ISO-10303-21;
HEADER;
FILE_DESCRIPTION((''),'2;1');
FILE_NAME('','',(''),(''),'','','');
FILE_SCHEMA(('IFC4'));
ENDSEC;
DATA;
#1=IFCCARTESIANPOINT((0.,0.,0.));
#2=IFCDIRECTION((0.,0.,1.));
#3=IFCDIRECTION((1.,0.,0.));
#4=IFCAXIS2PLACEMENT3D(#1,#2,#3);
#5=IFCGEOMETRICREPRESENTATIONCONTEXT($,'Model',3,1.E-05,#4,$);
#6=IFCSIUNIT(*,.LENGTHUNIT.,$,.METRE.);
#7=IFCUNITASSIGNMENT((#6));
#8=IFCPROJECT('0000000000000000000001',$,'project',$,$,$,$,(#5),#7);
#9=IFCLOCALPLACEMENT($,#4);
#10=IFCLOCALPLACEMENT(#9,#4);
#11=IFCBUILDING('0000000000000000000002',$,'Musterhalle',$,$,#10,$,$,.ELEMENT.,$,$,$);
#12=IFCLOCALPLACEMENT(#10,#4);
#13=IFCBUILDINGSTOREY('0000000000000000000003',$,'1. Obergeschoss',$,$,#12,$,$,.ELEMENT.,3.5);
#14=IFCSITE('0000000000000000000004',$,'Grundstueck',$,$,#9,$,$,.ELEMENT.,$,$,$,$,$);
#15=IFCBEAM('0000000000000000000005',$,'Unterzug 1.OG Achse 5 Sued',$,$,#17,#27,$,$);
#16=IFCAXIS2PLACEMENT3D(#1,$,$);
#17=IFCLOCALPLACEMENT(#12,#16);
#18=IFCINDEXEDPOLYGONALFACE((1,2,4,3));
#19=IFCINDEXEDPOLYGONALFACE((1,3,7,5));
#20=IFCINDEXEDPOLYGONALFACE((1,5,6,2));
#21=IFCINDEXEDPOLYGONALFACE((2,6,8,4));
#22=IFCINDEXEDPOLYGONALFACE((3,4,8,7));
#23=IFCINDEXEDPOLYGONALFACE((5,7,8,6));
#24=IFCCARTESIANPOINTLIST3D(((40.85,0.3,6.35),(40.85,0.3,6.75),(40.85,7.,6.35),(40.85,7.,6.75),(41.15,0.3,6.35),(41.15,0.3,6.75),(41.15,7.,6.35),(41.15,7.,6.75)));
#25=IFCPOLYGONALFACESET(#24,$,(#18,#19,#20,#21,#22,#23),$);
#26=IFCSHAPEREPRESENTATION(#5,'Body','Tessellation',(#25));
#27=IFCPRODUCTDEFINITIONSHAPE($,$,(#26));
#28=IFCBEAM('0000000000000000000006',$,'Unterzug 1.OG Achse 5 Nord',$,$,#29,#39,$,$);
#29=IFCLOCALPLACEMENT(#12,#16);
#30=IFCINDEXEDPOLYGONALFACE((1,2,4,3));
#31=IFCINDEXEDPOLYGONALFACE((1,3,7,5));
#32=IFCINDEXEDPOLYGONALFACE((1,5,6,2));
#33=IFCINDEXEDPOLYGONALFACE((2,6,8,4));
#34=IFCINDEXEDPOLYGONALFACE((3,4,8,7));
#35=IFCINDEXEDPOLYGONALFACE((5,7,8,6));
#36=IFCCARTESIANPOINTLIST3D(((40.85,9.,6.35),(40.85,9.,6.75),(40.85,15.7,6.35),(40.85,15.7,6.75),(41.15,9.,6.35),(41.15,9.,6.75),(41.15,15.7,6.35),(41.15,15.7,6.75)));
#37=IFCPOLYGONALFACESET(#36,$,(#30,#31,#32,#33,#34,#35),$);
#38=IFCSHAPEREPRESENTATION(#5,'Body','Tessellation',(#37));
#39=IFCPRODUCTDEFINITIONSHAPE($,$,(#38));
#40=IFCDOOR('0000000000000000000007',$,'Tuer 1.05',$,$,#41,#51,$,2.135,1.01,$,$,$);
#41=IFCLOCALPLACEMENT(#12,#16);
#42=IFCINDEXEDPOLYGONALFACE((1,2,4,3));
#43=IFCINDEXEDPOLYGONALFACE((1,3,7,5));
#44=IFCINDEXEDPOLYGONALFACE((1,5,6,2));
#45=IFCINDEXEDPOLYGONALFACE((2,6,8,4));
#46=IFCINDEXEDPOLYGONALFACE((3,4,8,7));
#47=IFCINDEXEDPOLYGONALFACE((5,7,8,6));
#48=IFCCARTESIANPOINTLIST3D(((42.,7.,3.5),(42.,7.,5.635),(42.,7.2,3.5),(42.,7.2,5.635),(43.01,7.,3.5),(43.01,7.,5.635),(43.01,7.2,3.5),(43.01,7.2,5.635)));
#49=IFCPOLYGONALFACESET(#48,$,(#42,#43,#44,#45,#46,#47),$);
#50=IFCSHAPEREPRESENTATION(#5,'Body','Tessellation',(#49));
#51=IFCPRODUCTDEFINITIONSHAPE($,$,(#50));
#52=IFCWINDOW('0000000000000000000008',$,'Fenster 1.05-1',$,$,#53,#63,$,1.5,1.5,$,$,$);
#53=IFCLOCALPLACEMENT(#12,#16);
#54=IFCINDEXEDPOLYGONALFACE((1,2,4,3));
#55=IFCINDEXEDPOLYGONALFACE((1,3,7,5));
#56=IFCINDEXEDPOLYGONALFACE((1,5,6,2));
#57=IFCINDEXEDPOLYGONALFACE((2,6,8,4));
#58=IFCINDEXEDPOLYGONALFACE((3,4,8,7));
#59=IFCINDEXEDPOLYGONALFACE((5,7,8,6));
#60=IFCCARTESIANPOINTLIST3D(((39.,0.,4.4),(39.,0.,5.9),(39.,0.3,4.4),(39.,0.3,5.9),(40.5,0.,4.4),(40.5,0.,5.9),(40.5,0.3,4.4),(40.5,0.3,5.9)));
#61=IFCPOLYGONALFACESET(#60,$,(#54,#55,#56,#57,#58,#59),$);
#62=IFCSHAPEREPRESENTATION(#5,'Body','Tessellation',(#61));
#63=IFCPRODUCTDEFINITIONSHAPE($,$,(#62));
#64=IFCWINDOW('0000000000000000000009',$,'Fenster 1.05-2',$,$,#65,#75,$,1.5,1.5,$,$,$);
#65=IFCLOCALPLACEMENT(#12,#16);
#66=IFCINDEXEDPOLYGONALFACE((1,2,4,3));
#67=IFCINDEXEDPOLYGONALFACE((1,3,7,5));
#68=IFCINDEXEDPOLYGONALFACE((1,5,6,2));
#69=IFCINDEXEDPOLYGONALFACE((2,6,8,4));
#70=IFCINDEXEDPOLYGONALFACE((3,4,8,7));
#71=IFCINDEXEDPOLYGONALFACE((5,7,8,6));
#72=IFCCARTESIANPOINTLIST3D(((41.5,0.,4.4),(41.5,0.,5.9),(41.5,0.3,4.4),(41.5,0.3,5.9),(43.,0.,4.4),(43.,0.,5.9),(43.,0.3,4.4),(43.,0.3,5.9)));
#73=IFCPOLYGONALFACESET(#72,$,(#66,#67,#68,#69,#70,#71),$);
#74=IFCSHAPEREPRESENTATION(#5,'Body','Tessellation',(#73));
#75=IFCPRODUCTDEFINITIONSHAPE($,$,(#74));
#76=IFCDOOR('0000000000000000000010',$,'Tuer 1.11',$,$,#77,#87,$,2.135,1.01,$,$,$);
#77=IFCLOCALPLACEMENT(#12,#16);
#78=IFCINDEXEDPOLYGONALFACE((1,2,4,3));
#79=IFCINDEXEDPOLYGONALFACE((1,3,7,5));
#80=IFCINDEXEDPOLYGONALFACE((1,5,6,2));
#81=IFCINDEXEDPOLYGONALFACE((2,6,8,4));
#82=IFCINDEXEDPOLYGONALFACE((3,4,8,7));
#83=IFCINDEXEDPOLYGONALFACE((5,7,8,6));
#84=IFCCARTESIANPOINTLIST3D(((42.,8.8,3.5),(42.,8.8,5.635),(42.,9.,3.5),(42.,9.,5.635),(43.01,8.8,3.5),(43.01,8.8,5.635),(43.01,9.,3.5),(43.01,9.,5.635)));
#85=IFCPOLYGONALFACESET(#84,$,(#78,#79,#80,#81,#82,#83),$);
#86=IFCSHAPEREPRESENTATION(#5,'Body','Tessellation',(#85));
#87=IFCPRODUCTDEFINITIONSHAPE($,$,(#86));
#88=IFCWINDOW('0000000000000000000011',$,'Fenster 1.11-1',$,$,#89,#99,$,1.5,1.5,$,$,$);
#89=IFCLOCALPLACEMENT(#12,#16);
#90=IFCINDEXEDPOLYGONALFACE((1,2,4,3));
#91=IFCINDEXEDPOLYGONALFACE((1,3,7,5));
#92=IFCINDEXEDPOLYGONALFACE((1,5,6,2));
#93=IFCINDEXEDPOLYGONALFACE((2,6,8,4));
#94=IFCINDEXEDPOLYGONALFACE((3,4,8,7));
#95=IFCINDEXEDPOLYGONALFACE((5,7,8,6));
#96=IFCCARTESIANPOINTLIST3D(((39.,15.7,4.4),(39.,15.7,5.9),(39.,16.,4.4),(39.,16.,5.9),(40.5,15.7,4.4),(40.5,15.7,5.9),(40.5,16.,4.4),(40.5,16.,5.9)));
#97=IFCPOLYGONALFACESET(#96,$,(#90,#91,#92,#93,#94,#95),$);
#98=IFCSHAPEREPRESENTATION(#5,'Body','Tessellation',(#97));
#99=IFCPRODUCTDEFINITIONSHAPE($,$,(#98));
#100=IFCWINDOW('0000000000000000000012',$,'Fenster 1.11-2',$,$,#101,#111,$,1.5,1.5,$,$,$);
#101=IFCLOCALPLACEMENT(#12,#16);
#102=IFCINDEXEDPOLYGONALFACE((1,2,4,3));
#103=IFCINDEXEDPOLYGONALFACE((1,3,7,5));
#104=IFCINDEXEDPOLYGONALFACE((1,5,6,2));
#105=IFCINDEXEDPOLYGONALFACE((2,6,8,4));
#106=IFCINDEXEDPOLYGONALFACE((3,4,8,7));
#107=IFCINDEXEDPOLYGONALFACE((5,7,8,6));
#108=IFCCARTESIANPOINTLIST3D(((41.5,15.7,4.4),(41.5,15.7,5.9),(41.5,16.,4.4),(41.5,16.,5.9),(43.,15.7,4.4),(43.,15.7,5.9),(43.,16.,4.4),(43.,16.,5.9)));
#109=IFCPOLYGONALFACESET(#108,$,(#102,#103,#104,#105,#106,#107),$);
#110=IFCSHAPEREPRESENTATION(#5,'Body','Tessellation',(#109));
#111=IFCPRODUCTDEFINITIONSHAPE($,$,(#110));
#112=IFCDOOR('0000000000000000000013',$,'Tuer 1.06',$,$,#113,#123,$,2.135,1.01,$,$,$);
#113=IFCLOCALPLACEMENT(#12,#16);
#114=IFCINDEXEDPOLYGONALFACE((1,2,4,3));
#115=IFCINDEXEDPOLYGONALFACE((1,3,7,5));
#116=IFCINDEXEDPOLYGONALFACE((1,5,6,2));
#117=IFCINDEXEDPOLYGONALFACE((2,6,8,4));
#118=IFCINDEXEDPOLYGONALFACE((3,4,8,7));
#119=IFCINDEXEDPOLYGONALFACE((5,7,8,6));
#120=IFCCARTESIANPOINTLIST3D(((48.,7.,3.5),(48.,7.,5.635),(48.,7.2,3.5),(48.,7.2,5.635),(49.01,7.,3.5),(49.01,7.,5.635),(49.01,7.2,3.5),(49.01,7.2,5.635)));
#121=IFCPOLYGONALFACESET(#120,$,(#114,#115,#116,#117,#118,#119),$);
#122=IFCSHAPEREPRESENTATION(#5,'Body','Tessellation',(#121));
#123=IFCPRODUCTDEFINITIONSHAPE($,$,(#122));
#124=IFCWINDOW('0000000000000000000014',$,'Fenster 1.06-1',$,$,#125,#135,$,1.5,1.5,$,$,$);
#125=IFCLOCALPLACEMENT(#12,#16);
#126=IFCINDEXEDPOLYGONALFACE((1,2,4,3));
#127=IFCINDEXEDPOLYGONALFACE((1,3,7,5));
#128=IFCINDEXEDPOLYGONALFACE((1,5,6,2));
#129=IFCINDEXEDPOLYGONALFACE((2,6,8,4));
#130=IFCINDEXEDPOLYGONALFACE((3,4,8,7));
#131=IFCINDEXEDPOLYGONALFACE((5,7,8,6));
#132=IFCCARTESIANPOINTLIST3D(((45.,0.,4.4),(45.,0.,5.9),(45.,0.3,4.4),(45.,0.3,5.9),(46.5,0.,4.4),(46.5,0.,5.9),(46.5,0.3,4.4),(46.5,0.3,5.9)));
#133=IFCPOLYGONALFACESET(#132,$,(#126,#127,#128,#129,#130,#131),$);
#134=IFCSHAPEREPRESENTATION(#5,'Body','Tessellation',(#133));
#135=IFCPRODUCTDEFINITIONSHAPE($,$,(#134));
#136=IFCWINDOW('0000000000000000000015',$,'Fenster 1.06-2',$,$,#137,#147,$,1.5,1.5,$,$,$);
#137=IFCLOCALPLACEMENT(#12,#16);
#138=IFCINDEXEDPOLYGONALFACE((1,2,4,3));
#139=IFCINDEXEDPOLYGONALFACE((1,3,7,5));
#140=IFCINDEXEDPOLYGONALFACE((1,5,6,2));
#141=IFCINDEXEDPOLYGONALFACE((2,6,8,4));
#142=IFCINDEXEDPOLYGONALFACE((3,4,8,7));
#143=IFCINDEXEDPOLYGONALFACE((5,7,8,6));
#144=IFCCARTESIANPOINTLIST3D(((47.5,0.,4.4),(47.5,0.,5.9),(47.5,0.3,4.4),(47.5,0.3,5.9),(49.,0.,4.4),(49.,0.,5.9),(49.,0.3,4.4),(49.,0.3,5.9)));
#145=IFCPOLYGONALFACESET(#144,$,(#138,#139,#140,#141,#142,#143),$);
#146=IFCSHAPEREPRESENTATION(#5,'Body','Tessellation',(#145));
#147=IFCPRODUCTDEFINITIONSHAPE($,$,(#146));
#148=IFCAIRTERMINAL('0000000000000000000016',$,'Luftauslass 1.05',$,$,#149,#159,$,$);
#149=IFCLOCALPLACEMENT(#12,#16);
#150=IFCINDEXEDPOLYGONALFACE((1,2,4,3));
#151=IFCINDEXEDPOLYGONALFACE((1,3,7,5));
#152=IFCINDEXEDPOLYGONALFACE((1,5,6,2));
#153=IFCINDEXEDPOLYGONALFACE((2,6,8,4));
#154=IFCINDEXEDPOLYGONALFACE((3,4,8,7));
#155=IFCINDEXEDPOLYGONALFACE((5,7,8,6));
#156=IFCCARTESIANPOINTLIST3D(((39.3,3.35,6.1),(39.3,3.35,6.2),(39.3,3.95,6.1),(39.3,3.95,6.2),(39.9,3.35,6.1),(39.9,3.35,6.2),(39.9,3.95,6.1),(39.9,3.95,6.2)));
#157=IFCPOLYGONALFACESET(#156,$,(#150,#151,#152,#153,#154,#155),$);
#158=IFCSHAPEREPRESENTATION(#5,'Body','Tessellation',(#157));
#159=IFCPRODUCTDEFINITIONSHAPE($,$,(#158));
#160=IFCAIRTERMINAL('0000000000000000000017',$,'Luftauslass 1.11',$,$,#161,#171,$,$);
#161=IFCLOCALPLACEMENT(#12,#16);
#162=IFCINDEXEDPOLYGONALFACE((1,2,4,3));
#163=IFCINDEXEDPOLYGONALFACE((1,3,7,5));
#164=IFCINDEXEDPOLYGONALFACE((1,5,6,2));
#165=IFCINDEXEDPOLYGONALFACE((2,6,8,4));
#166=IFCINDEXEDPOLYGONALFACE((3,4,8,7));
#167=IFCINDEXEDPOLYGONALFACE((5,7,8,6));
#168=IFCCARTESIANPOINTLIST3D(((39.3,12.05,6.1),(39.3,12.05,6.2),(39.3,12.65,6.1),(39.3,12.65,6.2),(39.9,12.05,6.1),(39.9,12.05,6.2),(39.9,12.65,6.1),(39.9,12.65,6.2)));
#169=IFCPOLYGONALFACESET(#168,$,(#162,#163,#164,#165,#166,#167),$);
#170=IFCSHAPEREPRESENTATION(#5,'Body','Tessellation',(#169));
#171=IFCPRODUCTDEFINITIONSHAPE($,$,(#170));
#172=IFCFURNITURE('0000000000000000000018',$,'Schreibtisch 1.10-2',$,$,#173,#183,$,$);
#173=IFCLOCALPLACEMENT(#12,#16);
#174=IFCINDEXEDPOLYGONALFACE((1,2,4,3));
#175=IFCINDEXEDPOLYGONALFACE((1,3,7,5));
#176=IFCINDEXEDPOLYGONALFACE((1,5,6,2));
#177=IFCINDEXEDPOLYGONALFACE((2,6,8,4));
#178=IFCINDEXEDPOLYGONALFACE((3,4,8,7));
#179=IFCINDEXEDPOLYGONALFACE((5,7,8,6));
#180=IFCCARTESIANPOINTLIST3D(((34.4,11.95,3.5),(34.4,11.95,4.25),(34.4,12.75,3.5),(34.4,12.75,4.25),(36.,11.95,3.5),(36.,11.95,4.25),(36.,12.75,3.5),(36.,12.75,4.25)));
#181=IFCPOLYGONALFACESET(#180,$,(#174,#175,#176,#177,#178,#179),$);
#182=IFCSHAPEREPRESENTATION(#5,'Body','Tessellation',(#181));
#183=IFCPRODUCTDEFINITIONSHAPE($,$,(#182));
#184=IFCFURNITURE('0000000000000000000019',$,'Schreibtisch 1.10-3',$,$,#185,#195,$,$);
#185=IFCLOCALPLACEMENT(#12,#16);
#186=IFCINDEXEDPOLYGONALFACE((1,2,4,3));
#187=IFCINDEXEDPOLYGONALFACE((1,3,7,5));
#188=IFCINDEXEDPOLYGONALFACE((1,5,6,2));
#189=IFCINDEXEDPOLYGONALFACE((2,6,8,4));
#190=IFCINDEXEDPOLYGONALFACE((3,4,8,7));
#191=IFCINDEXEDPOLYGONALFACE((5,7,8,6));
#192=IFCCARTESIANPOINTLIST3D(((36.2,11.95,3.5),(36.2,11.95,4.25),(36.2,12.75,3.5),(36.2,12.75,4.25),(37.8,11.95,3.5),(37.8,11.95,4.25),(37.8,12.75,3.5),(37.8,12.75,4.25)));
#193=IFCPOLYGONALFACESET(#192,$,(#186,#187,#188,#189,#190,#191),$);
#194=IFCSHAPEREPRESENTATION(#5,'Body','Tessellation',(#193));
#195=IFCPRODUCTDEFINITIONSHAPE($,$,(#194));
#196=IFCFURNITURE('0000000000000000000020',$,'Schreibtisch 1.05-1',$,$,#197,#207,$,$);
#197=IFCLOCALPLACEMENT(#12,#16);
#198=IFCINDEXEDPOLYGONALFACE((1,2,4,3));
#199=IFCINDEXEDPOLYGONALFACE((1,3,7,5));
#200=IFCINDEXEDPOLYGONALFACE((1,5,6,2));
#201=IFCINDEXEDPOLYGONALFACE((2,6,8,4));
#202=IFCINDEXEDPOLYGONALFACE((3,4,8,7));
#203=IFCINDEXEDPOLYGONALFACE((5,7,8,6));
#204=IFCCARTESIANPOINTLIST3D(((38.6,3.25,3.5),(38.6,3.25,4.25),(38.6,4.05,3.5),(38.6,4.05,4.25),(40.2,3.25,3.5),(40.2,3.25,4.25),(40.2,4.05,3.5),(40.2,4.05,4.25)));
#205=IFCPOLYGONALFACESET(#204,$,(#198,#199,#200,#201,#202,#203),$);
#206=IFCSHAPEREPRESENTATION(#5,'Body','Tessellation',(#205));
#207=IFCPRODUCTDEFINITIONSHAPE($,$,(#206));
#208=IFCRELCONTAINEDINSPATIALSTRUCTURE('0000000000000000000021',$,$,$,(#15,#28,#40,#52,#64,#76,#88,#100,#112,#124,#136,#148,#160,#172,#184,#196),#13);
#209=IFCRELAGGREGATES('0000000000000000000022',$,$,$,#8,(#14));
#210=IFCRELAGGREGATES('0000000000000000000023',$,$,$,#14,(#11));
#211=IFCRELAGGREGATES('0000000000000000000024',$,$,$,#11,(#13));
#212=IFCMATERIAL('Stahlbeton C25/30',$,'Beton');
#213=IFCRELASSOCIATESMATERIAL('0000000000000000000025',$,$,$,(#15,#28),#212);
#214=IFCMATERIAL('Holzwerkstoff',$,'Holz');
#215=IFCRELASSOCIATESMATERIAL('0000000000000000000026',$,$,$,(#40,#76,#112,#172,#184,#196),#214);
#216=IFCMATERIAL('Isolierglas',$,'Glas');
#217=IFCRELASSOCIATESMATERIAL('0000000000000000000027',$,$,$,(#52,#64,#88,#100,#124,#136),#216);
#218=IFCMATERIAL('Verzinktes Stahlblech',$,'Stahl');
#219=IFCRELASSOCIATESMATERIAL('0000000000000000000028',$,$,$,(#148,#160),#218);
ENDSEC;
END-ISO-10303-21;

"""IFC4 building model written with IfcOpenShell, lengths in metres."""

from ifc_helpers import new_model, si_unit, frame, origin_with_axes, origin_2d, place, context, project, spatial, rectangle, extrude, material, element, save


model = new_model("IFC4")

# Units and contexts
model_context = context("Model", 3, precision=1e-05, world=origin_with_axes())
ifc_project = project(units=[si_unit("LENGTHUNIT", "METRE")], contexts=[model_context])

# Site, building, storey
site_placement = place(None, origin_with_axes())
site = spatial("IfcSite", under=ifc_project, at=site_placement, Name="Grundstueck", CompositionType="ELEMENT")
building_placement = place(site_placement, origin_with_axes())
building = spatial("IfcBuilding", under=site, at=building_placement, Name="Musterhalle", CompositionType="ELEMENT")
storey_placement = place(building_placement, origin_with_axes())
storey = spatial("IfcBuildingStorey", under=building, at=storey_placement, Name="1. Obergeschoss", CompositionType="ELEMENT", Elevation=3.5)

# Beams
ifc_material_1 = material(Name="Stahlbeton C25/30", Category="Beton")
placement = place(storey_placement, origin_with_axes())
element("IfcBeam", 1, at=placement, inside=storey, material=ifc_material_1, Name="Unterzug 1.OG Achse 5 Sued", context=model_context, shape_type="SweptSolid", body=[
    extrude(rectangle(XDim=0.3, YDim=6.7, at=origin_2d()), frame((41.0, 3.65, 6.35), z_axis=(0.0, 0.0, 1.0), x_axis=(1.0, 0.0, 0.0)), (0.0, 0.0, 1.0), 0.4),
])
element("IfcBeam", 2, at=placement, inside=storey, material=ifc_material_1, Name="Unterzug 1.OG Achse 5 Nord", context=model_context, shape_type="SweptSolid", body=[
    extrude(rectangle(XDim=0.3, YDim=6.7, at=origin_2d()), frame((41.0, 12.35, 6.35), z_axis=(0.0, 0.0, 1.0), x_axis=(1.0, 0.0, 0.0)), (0.0, 0.0, 1.0), 0.4),
])

# Door
ifc_material_2 = material(Name="Holzwerkstoff", Category="Holz")
element("IfcDoor", 3, at=placement, inside=storey, material=ifc_material_2, Name="Tuer 1.05", OverallHeight=2.135, OverallWidth=1.01, context=model_context, shape_type="SweptSolid", body=[
    extrude(rectangle(XDim=1.01, YDim=0.2, at=origin_2d()), frame((42.505, 7.1, 3.5), z_axis=(0.0, 0.0, 1.0), x_axis=(1.0, 0.0, 0.0)), (0.0, 0.0, 1.0), 2.135),
])

# Windows
ifc_material_3 = material(Name="Isolierglas", Category="Glas")
element("IfcWindow", 4, at=placement, inside=storey, material=ifc_material_3, Name="Fenster 1.05-1", OverallHeight=1.5, OverallWidth=1.5, context=model_context, shape_type="SweptSolid", body=[
    extrude(rectangle(XDim=1.5, YDim=0.3, at=origin_2d()), frame((39.75, 0.15, 4.4), z_axis=(0.0, 0.0, 1.0), x_axis=(1.0, 0.0, 0.0)), (0.0, 0.0, 1.0), 1.5),
])
element("IfcWindow", 5, at=placement, inside=storey, material=ifc_material_3, Name="Fenster 1.05-2", OverallHeight=1.5, OverallWidth=1.5, context=model_context, shape_type="SweptSolid", body=[
    extrude(rectangle(XDim=1.5, YDim=0.3, at=origin_2d()), frame((42.25, 0.15, 4.4), z_axis=(0.0, 0.0, 1.0), x_axis=(1.0, 0.0, 0.0)), (0.0, 0.0, 1.0), 1.5),
])

# Door
element("IfcDoor", 6, at=placement, inside=storey, material=ifc_material_2, Name="Tuer 1.11", OverallHeight=2.135, OverallWidth=1.01, context=model_context, shape_type="SweptSolid", body=[
    extrude(rectangle(XDim=1.01, YDim=0.2, at=origin_2d()), frame((42.505, 8.9, 3.5), z_axis=(0.0, 0.0, 1.0), x_axis=(1.0, 0.0, 0.0)), (0.0, 0.0, 1.0), 2.135),
])

# Windows
element("IfcWindow", 7, at=placement, inside=storey, material=ifc_material_3, Name="Fenster 1.11-1", OverallHeight=1.5, OverallWidth=1.5, context=model_context, shape_type="SweptSolid", body=[
    extrude(rectangle(XDim=1.5, YDim=0.3, at=origin_2d()), frame((39.75, 15.85, 4.4), z_axis=(0.0, 0.0, 1.0), x_axis=(1.0, 0.0, 0.0)), (0.0, 0.0, 1.0), 1.5),
])
element("IfcWindow", 8, at=placement, inside=storey, material=ifc_material_3, Name="Fenster 1.11-2", OverallHeight=1.5, OverallWidth=1.5, context=model_context, shape_type="SweptSolid", body=[
    extrude(rectangle(XDim=1.5, YDim=0.3, at=origin_2d()), frame((42.25, 15.85, 4.4), z_axis=(0.0, 0.0, 1.0), x_axis=(1.0, 0.0, 0.0)), (0.0, 0.0, 1.0), 1.5),
])

# Door
element("IfcDoor", 9, at=placement, inside=storey, material=ifc_material_2, Name="Tuer 1.06", OverallHeight=2.135, OverallWidth=1.01, context=model_context, shape_type="SweptSolid", body=[
    extrude(rectangle(XDim=1.01, YDim=0.2, at=origin_2d()), frame((48.505, 7.1, 3.5), z_axis=(0.0, 0.0, 1.0), x_axis=(1.0, 0.0, 0.0)), (0.0, 0.0, 1.0), 2.135),
])

# Windows
element("IfcWindow", 10, at=placement, inside=storey, material=ifc_material_3, Name="Fenster 1.06-1", OverallHeight=1.5, OverallWidth=1.5, context=model_context, shape_type="SweptSolid", body=[
    extrude(rectangle(XDim=1.5, YDim=0.3, at=origin_2d()), frame((45.75, 0.15, 4.4), z_axis=(0.0, 0.0, 1.0), x_axis=(1.0, 0.0, 0.0)), (0.0, 0.0, 1.0), 1.5),
])
element("IfcWindow", 11, at=placement, inside=storey, material=ifc_material_3, Name="Fenster 1.06-2", OverallHeight=1.5, OverallWidth=1.5, context=model_context, shape_type="SweptSolid", body=[
    extrude(rectangle(XDim=1.5, YDim=0.3, at=origin_2d()), frame((48.25, 0.15, 4.4), z_axis=(0.0, 0.0, 1.0), x_axis=(1.0, 0.0, 0.0)), (0.0, 0.0, 1.0), 1.5),
])

# Air terminals
ifc_material_4 = material(Name="Verzinktes Stahlblech", Category="Stahl")
element("IfcAirTerminal", 12, at=placement, inside=storey, material=ifc_material_4, Name="Luftauslass 1.05", context=model_context, shape_type="SweptSolid", body=[
    extrude(rectangle(XDim=0.6, YDim=0.6, at=origin_2d()), frame((39.6, 3.65, 6.1), z_axis=(0.0, 0.0, 1.0), x_axis=(1.0, 0.0, 0.0)), (0.0, 0.0, 1.0), 0.1),
])
element("IfcAirTerminal", 13, at=placement, inside=storey, material=ifc_material_4, Name="Luftauslass 1.11", context=model_context, shape_type="SweptSolid", body=[
    extrude(rectangle(XDim=0.6, YDim=0.6, at=origin_2d()), frame((39.6, 12.35, 6.1), z_axis=(0.0, 0.0, 1.0), x_axis=(1.0, 0.0, 0.0)), (0.0, 0.0, 1.0), 0.1),
])

# Furniture
element("IfcFurniture", 14, at=placement, inside=storey, material=ifc_material_2, Name="Schreibtisch 1.10-2", context=model_context, shape_type="SweptSolid", body=[
    extrude(rectangle(XDim=1.6, YDim=0.8, at=origin_2d()), frame((35.2, 12.35, 3.5), z_axis=(0.0, 0.0, 1.0), x_axis=(1.0, 0.0, 0.0)), (0.0, 0.0, 1.0), 0.75),
])
element("IfcFurniture", 15, at=placement, inside=storey, material=ifc_material_2, Name="Schreibtisch 1.10-3", context=model_context, shape_type="SweptSolid", body=[
    extrude(rectangle(XDim=1.6, YDim=0.8, at=origin_2d()), frame((37.0, 12.35, 3.5), z_axis=(0.0, 0.0, 1.0), x_axis=(1.0, 0.0, 0.0)), (0.0, 0.0, 1.0), 0.75),
])
element("IfcFurniture", 16, at=placement, inside=storey, material=ifc_material_2, Name="Schreibtisch 1.05-1", context=model_context, shape_type="SweptSolid", body=[
    extrude(rectangle(XDim=1.6, YDim=0.8, at=origin_2d()), frame((39.4, 3.65, 3.5), z_axis=(0.0, 0.0, 1.0), x_axis=(1.0, 0.0, 0.0)), (0.0, 0.0, 1.0), 0.75),
])

save(model, "model.ifc")
